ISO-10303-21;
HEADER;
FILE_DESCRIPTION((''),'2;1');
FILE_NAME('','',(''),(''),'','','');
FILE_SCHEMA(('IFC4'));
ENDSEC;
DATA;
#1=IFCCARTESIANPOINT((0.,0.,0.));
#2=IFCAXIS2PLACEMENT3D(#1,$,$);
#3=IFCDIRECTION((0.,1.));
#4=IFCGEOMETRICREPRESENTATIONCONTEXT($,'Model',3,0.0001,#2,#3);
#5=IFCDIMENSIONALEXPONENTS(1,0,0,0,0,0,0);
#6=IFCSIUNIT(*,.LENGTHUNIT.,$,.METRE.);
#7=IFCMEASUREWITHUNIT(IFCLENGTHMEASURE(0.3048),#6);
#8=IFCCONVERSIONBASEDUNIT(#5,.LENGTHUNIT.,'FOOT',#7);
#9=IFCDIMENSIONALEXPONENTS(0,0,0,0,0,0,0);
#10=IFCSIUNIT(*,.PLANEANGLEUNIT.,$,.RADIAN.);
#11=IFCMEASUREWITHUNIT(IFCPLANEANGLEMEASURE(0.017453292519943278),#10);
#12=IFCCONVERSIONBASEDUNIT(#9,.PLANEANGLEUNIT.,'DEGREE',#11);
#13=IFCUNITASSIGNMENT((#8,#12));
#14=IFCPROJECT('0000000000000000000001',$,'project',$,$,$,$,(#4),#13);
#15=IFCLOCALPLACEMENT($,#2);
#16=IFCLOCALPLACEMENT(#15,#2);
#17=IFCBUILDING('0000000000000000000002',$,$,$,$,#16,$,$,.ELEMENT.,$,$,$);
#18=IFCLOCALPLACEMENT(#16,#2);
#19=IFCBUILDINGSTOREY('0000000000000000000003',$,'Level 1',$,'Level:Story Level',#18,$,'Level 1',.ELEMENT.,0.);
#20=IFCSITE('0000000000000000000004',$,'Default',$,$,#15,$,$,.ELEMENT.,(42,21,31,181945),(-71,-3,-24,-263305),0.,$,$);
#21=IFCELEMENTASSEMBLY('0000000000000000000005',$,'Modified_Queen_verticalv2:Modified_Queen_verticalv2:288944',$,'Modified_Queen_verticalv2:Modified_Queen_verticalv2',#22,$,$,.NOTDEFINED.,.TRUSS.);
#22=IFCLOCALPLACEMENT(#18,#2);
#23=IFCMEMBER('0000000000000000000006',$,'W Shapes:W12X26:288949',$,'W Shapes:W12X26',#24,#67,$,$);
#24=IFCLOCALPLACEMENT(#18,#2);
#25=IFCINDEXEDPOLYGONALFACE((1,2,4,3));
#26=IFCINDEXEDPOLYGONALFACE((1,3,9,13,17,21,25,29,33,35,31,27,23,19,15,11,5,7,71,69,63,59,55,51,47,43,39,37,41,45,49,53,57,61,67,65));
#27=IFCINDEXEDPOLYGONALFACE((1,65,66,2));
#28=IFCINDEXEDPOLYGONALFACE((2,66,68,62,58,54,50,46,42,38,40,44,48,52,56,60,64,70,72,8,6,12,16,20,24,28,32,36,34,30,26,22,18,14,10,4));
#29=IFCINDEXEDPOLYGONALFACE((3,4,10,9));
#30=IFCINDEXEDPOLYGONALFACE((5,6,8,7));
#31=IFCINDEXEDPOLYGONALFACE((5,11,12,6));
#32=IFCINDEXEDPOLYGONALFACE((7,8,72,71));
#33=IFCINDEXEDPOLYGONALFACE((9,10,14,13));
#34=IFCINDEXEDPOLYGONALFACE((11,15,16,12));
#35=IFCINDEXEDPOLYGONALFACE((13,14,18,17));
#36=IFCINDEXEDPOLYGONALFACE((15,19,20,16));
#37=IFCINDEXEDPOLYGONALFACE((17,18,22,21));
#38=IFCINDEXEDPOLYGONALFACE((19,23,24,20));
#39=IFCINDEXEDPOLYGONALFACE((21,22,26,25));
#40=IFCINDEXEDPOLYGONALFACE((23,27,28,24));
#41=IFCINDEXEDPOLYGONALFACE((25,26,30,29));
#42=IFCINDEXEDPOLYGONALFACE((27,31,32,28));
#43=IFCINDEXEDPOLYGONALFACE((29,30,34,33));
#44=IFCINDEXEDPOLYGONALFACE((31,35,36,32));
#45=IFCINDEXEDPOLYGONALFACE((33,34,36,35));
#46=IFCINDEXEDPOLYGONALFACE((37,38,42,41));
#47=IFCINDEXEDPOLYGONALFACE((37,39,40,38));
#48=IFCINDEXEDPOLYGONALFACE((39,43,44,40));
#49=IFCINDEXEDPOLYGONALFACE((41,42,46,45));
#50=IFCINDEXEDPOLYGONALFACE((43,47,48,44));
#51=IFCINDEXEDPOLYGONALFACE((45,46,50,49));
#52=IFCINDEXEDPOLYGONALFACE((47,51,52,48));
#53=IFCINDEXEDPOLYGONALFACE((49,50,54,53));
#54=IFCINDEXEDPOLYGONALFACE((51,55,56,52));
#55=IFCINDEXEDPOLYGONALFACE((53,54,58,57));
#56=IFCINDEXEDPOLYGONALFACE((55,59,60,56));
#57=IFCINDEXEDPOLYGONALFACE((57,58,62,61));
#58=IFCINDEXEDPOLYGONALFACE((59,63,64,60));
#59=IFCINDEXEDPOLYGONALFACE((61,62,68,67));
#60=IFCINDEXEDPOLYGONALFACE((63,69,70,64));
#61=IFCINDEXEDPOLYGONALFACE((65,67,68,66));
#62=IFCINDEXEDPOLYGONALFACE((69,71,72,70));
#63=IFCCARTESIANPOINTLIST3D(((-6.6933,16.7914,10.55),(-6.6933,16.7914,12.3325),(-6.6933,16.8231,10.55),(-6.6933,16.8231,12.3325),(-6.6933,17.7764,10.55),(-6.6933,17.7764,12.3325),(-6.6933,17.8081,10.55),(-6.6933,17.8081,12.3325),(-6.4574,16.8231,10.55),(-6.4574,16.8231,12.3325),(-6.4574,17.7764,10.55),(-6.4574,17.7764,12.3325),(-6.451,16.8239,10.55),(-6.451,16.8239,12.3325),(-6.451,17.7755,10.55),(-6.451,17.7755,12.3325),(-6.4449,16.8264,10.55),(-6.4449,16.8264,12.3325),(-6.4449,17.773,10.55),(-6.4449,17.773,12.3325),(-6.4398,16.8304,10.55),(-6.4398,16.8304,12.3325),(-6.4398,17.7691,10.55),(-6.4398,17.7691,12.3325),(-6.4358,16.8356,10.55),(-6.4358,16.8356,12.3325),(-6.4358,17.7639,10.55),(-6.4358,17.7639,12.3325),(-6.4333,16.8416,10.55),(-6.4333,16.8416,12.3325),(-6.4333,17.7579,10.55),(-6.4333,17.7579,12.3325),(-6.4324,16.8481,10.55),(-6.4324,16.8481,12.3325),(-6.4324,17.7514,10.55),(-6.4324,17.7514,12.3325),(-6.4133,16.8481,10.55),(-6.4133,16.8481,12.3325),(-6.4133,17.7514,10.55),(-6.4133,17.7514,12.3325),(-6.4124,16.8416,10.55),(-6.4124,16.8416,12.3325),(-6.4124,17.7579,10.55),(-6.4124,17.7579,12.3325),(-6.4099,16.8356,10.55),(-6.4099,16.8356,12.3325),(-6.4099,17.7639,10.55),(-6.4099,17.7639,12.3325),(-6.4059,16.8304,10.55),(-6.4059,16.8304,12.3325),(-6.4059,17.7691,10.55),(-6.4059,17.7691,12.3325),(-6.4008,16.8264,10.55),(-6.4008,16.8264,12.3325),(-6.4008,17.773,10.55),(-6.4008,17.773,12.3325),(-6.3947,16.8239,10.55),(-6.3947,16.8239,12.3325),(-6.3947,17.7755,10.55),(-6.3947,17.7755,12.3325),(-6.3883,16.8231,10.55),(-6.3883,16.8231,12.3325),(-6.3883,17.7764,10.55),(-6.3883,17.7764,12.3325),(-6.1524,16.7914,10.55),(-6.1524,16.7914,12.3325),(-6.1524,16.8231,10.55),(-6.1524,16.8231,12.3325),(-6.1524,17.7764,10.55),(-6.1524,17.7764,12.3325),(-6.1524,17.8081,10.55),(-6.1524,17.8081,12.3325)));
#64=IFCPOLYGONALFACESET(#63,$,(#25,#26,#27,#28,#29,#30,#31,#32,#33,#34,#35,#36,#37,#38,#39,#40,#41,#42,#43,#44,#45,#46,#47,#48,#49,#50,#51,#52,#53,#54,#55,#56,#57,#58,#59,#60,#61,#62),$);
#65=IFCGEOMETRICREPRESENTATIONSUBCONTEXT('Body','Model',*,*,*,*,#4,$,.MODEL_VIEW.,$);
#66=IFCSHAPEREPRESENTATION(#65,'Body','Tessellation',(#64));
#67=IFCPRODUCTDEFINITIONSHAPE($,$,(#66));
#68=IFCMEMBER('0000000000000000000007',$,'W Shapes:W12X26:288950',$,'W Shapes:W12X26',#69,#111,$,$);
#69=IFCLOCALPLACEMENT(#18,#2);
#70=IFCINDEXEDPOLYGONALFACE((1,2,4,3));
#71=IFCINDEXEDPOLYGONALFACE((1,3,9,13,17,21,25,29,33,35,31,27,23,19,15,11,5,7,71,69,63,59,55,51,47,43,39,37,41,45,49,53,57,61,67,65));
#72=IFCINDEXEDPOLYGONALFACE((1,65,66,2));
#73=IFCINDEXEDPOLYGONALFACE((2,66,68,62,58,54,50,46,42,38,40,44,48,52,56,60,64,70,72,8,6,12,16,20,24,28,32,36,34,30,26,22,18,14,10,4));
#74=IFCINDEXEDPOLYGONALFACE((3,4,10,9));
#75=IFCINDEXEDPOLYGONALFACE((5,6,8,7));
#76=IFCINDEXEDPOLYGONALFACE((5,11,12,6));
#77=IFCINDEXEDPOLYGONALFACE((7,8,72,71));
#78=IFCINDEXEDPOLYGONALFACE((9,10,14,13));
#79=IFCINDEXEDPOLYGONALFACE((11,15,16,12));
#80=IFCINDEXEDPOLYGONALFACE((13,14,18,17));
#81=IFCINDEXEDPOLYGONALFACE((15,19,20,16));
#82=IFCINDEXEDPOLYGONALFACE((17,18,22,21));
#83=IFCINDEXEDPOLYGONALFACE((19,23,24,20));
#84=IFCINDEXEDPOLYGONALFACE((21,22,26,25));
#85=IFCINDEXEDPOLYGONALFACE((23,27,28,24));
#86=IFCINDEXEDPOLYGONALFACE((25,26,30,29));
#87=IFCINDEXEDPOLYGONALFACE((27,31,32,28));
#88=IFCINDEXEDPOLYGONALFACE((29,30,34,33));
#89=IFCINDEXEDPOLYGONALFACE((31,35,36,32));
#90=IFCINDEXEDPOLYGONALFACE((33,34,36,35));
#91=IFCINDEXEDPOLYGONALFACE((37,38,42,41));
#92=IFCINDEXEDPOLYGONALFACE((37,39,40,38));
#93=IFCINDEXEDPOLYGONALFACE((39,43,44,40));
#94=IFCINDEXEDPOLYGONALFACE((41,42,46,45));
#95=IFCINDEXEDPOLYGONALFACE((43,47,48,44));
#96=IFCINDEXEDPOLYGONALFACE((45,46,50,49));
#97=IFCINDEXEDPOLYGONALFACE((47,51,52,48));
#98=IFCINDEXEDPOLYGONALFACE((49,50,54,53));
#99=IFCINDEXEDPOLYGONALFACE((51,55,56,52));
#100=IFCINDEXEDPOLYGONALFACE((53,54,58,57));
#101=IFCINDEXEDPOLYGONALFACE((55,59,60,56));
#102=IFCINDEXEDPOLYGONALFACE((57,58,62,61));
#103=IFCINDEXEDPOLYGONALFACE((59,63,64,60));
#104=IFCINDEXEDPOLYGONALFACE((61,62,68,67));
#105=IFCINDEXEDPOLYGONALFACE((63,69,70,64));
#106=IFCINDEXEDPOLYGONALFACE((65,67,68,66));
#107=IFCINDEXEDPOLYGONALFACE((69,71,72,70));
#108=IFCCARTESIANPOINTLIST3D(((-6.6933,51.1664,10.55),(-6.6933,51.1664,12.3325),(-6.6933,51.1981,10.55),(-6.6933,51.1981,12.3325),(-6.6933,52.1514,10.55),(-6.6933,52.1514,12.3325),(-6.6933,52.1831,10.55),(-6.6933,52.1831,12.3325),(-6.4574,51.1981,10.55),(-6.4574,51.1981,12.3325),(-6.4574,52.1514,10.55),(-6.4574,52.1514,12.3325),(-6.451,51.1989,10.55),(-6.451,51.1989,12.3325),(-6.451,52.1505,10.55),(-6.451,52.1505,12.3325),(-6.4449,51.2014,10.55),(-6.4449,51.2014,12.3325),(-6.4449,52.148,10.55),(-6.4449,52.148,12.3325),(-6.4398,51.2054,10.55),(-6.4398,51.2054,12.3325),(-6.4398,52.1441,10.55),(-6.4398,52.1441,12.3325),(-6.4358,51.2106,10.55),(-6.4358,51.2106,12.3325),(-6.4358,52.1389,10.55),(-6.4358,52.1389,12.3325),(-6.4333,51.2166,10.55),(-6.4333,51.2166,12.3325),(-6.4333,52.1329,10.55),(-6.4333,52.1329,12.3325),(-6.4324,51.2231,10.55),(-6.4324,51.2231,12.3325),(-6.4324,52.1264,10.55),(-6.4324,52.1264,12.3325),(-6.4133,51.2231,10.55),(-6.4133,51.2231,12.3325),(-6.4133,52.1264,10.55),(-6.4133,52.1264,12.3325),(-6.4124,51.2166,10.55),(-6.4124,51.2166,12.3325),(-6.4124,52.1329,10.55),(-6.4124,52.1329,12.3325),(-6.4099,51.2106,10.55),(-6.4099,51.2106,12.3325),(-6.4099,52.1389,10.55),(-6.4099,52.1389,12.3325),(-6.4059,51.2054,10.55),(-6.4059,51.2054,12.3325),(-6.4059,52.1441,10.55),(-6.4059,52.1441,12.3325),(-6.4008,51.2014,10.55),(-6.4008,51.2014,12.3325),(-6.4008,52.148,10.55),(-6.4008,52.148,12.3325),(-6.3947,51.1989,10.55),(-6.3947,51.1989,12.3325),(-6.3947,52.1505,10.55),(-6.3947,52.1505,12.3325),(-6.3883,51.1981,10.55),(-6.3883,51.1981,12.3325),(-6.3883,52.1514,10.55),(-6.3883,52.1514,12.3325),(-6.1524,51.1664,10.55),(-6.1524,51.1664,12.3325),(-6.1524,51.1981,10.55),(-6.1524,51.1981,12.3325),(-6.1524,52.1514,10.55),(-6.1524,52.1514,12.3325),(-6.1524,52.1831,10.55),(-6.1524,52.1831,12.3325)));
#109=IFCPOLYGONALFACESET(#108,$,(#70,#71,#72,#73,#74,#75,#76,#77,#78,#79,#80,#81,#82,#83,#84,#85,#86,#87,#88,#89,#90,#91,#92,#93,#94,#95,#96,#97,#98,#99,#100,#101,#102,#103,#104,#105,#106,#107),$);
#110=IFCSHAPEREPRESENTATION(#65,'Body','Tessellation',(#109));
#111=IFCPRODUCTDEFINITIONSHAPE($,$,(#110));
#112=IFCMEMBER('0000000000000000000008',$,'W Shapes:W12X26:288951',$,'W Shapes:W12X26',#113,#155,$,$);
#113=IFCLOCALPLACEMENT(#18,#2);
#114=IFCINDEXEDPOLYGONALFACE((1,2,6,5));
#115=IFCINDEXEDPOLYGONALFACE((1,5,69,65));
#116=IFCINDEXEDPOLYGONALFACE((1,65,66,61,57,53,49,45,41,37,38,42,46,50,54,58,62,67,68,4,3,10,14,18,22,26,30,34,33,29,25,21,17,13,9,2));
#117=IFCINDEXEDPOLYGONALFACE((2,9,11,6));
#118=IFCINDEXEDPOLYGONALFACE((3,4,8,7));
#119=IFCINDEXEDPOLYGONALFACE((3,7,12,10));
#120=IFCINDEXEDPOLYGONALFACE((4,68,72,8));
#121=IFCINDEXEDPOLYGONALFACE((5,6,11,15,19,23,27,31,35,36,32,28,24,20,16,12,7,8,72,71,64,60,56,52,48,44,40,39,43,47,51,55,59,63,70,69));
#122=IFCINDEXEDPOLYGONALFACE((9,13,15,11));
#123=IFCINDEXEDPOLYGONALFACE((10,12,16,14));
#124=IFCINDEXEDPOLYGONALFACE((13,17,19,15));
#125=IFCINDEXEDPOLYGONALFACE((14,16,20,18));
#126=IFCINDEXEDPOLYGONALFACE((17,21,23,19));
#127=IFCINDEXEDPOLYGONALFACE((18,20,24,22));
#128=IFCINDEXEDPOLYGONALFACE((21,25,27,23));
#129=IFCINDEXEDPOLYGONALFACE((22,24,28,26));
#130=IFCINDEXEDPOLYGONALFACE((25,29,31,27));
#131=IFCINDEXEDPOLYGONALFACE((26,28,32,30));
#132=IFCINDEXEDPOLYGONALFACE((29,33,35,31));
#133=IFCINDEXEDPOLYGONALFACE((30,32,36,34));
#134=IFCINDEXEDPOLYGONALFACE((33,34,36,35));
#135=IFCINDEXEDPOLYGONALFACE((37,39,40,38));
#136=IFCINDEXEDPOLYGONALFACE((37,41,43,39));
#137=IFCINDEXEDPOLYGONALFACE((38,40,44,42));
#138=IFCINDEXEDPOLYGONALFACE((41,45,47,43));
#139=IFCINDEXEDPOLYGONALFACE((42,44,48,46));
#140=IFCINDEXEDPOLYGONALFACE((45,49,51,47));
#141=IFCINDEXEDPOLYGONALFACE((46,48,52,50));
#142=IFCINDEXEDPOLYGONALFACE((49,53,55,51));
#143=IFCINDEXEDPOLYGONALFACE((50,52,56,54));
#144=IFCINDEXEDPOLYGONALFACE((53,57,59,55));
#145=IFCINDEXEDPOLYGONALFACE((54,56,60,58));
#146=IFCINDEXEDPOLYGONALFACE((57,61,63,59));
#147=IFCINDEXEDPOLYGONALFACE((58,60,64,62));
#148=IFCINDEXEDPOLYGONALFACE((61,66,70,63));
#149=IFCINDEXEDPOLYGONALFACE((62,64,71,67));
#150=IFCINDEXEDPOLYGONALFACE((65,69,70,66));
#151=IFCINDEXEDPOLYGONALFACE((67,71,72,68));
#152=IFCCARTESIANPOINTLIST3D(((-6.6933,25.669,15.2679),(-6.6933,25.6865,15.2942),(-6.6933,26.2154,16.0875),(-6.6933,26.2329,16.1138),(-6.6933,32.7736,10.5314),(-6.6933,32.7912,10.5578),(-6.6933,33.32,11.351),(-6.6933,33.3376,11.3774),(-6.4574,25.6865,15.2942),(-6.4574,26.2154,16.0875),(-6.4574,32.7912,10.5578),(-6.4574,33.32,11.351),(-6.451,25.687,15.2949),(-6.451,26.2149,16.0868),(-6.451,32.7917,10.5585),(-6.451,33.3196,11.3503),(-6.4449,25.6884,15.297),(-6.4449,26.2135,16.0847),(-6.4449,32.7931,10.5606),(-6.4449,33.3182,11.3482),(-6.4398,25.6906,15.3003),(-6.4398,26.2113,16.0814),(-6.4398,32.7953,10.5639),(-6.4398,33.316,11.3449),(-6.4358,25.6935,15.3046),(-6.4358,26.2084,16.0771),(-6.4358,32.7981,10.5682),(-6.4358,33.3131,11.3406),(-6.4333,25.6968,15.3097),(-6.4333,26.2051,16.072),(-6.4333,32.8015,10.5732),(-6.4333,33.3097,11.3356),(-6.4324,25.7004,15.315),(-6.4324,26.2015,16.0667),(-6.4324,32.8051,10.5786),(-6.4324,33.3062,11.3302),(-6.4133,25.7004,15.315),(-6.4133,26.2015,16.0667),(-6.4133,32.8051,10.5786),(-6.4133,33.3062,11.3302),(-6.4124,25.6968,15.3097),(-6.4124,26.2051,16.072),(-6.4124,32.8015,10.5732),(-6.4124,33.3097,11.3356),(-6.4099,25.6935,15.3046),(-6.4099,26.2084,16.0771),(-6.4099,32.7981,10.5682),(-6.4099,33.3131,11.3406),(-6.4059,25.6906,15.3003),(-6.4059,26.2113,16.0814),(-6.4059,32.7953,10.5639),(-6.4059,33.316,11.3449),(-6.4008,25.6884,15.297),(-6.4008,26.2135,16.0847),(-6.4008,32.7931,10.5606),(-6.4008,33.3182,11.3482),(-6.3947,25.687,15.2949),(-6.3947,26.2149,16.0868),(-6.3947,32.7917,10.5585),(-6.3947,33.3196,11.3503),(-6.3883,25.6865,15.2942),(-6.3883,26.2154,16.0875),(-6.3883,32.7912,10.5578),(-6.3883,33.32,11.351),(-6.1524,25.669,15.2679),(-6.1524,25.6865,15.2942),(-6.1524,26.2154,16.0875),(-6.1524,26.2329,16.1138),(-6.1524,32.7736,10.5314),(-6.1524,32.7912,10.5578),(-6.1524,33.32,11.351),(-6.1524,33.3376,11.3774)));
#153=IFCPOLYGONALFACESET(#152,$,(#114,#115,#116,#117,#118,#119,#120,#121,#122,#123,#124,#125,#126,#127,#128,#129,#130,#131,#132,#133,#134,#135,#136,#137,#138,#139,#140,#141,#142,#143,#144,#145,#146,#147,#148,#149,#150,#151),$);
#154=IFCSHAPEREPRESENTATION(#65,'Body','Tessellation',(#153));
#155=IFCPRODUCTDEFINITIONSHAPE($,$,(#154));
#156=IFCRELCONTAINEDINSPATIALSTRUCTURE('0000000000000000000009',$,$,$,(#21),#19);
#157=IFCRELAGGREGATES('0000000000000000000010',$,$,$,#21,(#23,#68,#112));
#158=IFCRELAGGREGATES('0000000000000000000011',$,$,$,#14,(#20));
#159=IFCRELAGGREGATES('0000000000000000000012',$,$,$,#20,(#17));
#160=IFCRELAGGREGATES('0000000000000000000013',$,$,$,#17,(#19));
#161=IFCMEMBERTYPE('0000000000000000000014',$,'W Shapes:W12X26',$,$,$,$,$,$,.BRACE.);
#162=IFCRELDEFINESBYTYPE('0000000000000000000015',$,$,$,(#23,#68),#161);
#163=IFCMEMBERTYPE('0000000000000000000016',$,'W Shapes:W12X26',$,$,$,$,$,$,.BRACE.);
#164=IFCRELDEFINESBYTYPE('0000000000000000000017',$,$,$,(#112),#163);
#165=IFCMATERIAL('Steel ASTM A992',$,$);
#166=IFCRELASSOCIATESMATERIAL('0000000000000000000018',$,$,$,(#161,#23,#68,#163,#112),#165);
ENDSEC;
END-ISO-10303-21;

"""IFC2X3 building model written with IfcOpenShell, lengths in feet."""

from ifc_helpers import new_model, entity, si_unit, converted_unit, direction, frame, frame_2d, origin, place, context, subcontext, project, spatial, polyline, circle_curve, parameter, trimmed, segment, composite_curve, outline, extrude, source, transform, mapped, material, type_object, type_shapes, element, aggregate, save


model = new_model("IFC2X3")

# Units and contexts
model_context = context("Model", 3, precision=0.0001, world=origin(), true_north=direction((0.0, 1.0)))
body_context = subcontext(model_context, "Body", "Model", "MODEL_VIEW")
ifc_project = project(units=[converted_unit("LENGTHUNIT", "FOOT", entity("IfcLengthMeasure", 0.3048), si_unit("LENGTHUNIT", "METRE"), dimensions=[1, 0, 0, 0, 0, 0, 0]), converted_unit("PLANEANGLEUNIT", "DEGREE", entity("IfcPlaneAngleMeasure", 0.017453292519943278), si_unit("PLANEANGLEUNIT", "RADIAN"), dimensions=[0, 0, 0, 0, 0, 0, 0])], contexts=[model_context])

# Site, building, storey
site_placement = place(None, origin())
site = spatial("IfcSite", under=ifc_project, at=site_placement, Name="Default", CompositionType="ELEMENT", RefLatitude=(42, 21, 31, 181945), RefLongitude=(-71, -3, -24, -263305), RefElevation=0.0)
building_placement = place(site_placement, origin())
building = spatial("IfcBuilding", under=site, at=building_placement, CompositionType="ELEMENT")
storey_placement = place(building_placement, origin())
storey = spatial("IfcBuildingStorey", under=building, at=storey_placement, Name="Level 1", ObjectType="Level:Story Level", LongName="Level 1", CompositionType="ELEMENT", Elevation=0.0)

# Element assembly, members
assembly_placement = place(storey_placement, origin())
assembly = element("IfcElementAssembly", 1, at=assembly_placement, inside=storey, Name="Modified_Queen_verticalv2:Modified_Queen_verticalv2:288944", ObjectType="Modified_Queen_verticalv2:Modified_Queen_verticalv2", AssemblyPlace="NOTDEFINED", PredefinedType="TRUSS")
ifc_material = material(Name="Steel ASTM A992")
member_type_1 = type_object("IfcMemberType", Name="W Shapes:W12X26", PredefinedType="BRACE", material=ifc_material)
shared_shape_1 = source(origin(), body_context, "Body", "SweptSolid", [
    extrude(outline(composite_curve([segment(polyline([(-0.2704, -0.4767), (-0.2704, -0.5083)]), True, "CONTINUOUS"), segment(polyline([(-0.2704, -0.5083), (0.2704, -0.5083)]), True, "CONTINUOUS"), segment(polyline([(0.2704, -0.5083), (0.2704, -0.4767)]), True, "CONTINUOUS"), segment(polyline([(0.2704, -0.4767), (0.0346, -0.4767)]), True, "CONTINUOUS"), segment(trimmed(circle_curve(frame_2d((0.0346, -0.4517), x_axis=(0.0, -1.0)), 0.025), [parameter(270.0)], [parameter(360.0)], True, "PARAMETER"), False, "CONTINUOUS"), segment(polyline([(0.0096, -0.4517), (0.0096, 0.4517)]), True, "CONTINUOUS"), segment(trimmed(circle_curve(frame_2d((0.0346, 0.4517), x_axis=(-1.0, 0.0)), 0.025), [parameter(270.0)], [parameter(360.0)], True, "PARAMETER"), False, "CONTINUOUS"), segment(polyline([(0.0346, 0.4767), (0.2704, 0.4767)]), True, "CONTINUOUS"), segment(polyline([(0.2704, 0.4767), (0.2704, 0.5083)]), True, "CONTINUOUS"), segment(polyline([(0.2704, 0.5083), (-0.2704, 0.5083)]), True, "CONTINUOUS"), segment(polyline([(-0.2704, 0.5083), (-0.2704, 0.4767)]), True, "CONTINUOUS"), segment(polyline([(-0.2704, 0.4767), (-0.0346, 0.4767)]), True, "CONTINUOUS"), segment(trimmed(circle_curve(frame_2d((-0.0346, 0.4517), x_axis=(0.0, 1.0)), 0.025), [parameter(270.0)], [parameter(0.0)], True, "PARAMETER"), False, "CONTINUOUS"), segment(polyline([(-0.0096, 0.4517), (-0.0096, -0.4517)]), True, "CONTINUOUS"), segment(trimmed(circle_curve(frame_2d((-0.0346, -0.4517), x_axis=(1.0, 0.0)), 0.025), [parameter(270.0)], [parameter(0.0)], True, "PARAMETER"), False, "CONTINUOUS"), segment(polyline([(-0.0346, -0.4767), (-0.2704, -0.4767)]), True, "CONTINUOUS")], self_intersect=False)), frame((-1.0125, 0.0, 0.0), z_axis=(-1.0, 0.0, 0.0), x_axis=(0.0, -1.0, 0.0)), (0.0, 0.0, -1.0), 1.7825),
])
type_shapes(member_type_1, [shared_shape_1])
member_1_placement = place(assembly_placement, frame((-6.4228, 17.2997, 11.5625), z_axis=(0.0, 1.0, 0.0), x_axis=(0.0, 0.0, 1.0)))
member_1 = element("IfcMember", 2, at=member_1_placement, type_object=member_type_1, material=ifc_material, Name="W Shapes:W12X26:288949", ObjectType="W Shapes:W12X26", context=body_context, shape_type="MappedRepresentation", body=[
    mapped(shared_shape_1, transform((0.0, 0.0, 0.0), scale=1.0)),
])
member_2_placement = place(assembly_placement, frame((-6.4228, 51.6747, 11.5625), z_axis=(0.0, 1.0, 0.0), x_axis=(0.0, 0.0, 1.0)))
member_2 = element("IfcMember", 3, at=member_2_placement, type_object=member_type_1, material=ifc_material, Name="W Shapes:W12X26:288950", ObjectType="W Shapes:W12X26", context=body_context, shape_type="MappedRepresentation", body=[
    mapped(shared_shape_1, transform((0.0, 0.0, 0.0), scale=1.0)),
])
member_type_2 = type_object("IfcMemberType", Name="W Shapes:W12X26", PredefinedType="BRACE", material=ifc_material)
shared_shape_2 = source(origin(), body_context, "Body", "SweptSolid", [
    extrude(outline(composite_curve([segment(polyline([(-0.2704, -0.4767), (-0.2704, -0.5083)]), True, "CONTINUOUS"), segment(polyline([(-0.2704, -0.5083), (0.2704, -0.5083)]), True, "CONTINUOUS"), segment(polyline([(0.2704, -0.5083), (0.2704, -0.4767)]), True, "CONTINUOUS"), segment(polyline([(0.2704, -0.4767), (0.0346, -0.4767)]), True, "CONTINUOUS"), segment(trimmed(circle_curve(frame_2d((0.0346, -0.4517), x_axis=(1.0, 0.0)), 0.025), [parameter(180.0)], [parameter(270.0)], True, "PARAMETER"), False, "CONTINUOUS"), segment(polyline([(0.0096, -0.4517), (0.0096, 0.4517)]), True, "CONTINUOUS"), segment(trimmed(circle_curve(frame_2d((0.0346, 0.4517), x_axis=(1.0, 0.0)), 0.025), [parameter(90.0)], [parameter(180.0)], True, "PARAMETER"), False, "CONTINUOUS"), segment(polyline([(0.0346, 0.4767), (0.2704, 0.4767)]), True, "CONTINUOUS"), segment(polyline([(0.2704, 0.4767), (0.2704, 0.5083)]), True, "CONTINUOUS"), segment(polyline([(0.2704, 0.5083), (-0.2704, 0.5083)]), True, "CONTINUOUS"), segment(polyline([(-0.2704, 0.5083), (-0.2704, 0.4767)]), True, "CONTINUOUS"), segment(polyline([(-0.2704, 0.4767), (-0.0346, 0.4767)]), True, "CONTINUOUS"), segment(trimmed(circle_curve(frame_2d((-0.0346, 0.4517), x_axis=(1.0, 0.0)), 0.025), [parameter(360.0)], [parameter(90.0)], True, "PARAMETER"), False, "CONTINUOUS"), segment(polyline([(-0.0096, 0.4517), (-0.0096, -0.4517)]), True, "CONTINUOUS"), segment(trimmed(circle_curve(frame_2d((-0.0346, -0.4517), x_axis=(1.0, 0.0)), 0.025), [parameter(270.0)], [parameter(360.0)], True, "PARAMETER"), False, "CONTINUOUS"), segment(polyline([(-0.0346, -0.4767), (-0.2704, -0.4767)]), True, "CONTINUOUS")], self_intersect=False)), frame((-4.6257, 0.0, 0.0), z_axis=(-1.0, 0.0, 0.0), x_axis=(0.0, -1.0, 0.0)), (0.0, 0.0, -1.0), 8.5387),
])
type_shapes(member_type_2, [shared_shape_2])
member_3_placement = place(assembly_placement, frame((-6.4228, 29.7997, 13.125), z_axis=(0.0, -0.5547, -0.83205), x_axis=(0.0, 0.83205, -0.5547)))
member_3 = element("IfcMember", 4, at=member_3_placement, type_object=member_type_2, material=ifc_material, Name="W Shapes:W12X26:288951", ObjectType="W Shapes:W12X26", context=body_context, shape_type="MappedRepresentation", body=[
    mapped(shared_shape_2, transform((0.0, 0.0, 0.0), scale=1.0)),
])
aggregate(assembly, [member_1, member_2, member_3])

save(model, "model.ifc")
